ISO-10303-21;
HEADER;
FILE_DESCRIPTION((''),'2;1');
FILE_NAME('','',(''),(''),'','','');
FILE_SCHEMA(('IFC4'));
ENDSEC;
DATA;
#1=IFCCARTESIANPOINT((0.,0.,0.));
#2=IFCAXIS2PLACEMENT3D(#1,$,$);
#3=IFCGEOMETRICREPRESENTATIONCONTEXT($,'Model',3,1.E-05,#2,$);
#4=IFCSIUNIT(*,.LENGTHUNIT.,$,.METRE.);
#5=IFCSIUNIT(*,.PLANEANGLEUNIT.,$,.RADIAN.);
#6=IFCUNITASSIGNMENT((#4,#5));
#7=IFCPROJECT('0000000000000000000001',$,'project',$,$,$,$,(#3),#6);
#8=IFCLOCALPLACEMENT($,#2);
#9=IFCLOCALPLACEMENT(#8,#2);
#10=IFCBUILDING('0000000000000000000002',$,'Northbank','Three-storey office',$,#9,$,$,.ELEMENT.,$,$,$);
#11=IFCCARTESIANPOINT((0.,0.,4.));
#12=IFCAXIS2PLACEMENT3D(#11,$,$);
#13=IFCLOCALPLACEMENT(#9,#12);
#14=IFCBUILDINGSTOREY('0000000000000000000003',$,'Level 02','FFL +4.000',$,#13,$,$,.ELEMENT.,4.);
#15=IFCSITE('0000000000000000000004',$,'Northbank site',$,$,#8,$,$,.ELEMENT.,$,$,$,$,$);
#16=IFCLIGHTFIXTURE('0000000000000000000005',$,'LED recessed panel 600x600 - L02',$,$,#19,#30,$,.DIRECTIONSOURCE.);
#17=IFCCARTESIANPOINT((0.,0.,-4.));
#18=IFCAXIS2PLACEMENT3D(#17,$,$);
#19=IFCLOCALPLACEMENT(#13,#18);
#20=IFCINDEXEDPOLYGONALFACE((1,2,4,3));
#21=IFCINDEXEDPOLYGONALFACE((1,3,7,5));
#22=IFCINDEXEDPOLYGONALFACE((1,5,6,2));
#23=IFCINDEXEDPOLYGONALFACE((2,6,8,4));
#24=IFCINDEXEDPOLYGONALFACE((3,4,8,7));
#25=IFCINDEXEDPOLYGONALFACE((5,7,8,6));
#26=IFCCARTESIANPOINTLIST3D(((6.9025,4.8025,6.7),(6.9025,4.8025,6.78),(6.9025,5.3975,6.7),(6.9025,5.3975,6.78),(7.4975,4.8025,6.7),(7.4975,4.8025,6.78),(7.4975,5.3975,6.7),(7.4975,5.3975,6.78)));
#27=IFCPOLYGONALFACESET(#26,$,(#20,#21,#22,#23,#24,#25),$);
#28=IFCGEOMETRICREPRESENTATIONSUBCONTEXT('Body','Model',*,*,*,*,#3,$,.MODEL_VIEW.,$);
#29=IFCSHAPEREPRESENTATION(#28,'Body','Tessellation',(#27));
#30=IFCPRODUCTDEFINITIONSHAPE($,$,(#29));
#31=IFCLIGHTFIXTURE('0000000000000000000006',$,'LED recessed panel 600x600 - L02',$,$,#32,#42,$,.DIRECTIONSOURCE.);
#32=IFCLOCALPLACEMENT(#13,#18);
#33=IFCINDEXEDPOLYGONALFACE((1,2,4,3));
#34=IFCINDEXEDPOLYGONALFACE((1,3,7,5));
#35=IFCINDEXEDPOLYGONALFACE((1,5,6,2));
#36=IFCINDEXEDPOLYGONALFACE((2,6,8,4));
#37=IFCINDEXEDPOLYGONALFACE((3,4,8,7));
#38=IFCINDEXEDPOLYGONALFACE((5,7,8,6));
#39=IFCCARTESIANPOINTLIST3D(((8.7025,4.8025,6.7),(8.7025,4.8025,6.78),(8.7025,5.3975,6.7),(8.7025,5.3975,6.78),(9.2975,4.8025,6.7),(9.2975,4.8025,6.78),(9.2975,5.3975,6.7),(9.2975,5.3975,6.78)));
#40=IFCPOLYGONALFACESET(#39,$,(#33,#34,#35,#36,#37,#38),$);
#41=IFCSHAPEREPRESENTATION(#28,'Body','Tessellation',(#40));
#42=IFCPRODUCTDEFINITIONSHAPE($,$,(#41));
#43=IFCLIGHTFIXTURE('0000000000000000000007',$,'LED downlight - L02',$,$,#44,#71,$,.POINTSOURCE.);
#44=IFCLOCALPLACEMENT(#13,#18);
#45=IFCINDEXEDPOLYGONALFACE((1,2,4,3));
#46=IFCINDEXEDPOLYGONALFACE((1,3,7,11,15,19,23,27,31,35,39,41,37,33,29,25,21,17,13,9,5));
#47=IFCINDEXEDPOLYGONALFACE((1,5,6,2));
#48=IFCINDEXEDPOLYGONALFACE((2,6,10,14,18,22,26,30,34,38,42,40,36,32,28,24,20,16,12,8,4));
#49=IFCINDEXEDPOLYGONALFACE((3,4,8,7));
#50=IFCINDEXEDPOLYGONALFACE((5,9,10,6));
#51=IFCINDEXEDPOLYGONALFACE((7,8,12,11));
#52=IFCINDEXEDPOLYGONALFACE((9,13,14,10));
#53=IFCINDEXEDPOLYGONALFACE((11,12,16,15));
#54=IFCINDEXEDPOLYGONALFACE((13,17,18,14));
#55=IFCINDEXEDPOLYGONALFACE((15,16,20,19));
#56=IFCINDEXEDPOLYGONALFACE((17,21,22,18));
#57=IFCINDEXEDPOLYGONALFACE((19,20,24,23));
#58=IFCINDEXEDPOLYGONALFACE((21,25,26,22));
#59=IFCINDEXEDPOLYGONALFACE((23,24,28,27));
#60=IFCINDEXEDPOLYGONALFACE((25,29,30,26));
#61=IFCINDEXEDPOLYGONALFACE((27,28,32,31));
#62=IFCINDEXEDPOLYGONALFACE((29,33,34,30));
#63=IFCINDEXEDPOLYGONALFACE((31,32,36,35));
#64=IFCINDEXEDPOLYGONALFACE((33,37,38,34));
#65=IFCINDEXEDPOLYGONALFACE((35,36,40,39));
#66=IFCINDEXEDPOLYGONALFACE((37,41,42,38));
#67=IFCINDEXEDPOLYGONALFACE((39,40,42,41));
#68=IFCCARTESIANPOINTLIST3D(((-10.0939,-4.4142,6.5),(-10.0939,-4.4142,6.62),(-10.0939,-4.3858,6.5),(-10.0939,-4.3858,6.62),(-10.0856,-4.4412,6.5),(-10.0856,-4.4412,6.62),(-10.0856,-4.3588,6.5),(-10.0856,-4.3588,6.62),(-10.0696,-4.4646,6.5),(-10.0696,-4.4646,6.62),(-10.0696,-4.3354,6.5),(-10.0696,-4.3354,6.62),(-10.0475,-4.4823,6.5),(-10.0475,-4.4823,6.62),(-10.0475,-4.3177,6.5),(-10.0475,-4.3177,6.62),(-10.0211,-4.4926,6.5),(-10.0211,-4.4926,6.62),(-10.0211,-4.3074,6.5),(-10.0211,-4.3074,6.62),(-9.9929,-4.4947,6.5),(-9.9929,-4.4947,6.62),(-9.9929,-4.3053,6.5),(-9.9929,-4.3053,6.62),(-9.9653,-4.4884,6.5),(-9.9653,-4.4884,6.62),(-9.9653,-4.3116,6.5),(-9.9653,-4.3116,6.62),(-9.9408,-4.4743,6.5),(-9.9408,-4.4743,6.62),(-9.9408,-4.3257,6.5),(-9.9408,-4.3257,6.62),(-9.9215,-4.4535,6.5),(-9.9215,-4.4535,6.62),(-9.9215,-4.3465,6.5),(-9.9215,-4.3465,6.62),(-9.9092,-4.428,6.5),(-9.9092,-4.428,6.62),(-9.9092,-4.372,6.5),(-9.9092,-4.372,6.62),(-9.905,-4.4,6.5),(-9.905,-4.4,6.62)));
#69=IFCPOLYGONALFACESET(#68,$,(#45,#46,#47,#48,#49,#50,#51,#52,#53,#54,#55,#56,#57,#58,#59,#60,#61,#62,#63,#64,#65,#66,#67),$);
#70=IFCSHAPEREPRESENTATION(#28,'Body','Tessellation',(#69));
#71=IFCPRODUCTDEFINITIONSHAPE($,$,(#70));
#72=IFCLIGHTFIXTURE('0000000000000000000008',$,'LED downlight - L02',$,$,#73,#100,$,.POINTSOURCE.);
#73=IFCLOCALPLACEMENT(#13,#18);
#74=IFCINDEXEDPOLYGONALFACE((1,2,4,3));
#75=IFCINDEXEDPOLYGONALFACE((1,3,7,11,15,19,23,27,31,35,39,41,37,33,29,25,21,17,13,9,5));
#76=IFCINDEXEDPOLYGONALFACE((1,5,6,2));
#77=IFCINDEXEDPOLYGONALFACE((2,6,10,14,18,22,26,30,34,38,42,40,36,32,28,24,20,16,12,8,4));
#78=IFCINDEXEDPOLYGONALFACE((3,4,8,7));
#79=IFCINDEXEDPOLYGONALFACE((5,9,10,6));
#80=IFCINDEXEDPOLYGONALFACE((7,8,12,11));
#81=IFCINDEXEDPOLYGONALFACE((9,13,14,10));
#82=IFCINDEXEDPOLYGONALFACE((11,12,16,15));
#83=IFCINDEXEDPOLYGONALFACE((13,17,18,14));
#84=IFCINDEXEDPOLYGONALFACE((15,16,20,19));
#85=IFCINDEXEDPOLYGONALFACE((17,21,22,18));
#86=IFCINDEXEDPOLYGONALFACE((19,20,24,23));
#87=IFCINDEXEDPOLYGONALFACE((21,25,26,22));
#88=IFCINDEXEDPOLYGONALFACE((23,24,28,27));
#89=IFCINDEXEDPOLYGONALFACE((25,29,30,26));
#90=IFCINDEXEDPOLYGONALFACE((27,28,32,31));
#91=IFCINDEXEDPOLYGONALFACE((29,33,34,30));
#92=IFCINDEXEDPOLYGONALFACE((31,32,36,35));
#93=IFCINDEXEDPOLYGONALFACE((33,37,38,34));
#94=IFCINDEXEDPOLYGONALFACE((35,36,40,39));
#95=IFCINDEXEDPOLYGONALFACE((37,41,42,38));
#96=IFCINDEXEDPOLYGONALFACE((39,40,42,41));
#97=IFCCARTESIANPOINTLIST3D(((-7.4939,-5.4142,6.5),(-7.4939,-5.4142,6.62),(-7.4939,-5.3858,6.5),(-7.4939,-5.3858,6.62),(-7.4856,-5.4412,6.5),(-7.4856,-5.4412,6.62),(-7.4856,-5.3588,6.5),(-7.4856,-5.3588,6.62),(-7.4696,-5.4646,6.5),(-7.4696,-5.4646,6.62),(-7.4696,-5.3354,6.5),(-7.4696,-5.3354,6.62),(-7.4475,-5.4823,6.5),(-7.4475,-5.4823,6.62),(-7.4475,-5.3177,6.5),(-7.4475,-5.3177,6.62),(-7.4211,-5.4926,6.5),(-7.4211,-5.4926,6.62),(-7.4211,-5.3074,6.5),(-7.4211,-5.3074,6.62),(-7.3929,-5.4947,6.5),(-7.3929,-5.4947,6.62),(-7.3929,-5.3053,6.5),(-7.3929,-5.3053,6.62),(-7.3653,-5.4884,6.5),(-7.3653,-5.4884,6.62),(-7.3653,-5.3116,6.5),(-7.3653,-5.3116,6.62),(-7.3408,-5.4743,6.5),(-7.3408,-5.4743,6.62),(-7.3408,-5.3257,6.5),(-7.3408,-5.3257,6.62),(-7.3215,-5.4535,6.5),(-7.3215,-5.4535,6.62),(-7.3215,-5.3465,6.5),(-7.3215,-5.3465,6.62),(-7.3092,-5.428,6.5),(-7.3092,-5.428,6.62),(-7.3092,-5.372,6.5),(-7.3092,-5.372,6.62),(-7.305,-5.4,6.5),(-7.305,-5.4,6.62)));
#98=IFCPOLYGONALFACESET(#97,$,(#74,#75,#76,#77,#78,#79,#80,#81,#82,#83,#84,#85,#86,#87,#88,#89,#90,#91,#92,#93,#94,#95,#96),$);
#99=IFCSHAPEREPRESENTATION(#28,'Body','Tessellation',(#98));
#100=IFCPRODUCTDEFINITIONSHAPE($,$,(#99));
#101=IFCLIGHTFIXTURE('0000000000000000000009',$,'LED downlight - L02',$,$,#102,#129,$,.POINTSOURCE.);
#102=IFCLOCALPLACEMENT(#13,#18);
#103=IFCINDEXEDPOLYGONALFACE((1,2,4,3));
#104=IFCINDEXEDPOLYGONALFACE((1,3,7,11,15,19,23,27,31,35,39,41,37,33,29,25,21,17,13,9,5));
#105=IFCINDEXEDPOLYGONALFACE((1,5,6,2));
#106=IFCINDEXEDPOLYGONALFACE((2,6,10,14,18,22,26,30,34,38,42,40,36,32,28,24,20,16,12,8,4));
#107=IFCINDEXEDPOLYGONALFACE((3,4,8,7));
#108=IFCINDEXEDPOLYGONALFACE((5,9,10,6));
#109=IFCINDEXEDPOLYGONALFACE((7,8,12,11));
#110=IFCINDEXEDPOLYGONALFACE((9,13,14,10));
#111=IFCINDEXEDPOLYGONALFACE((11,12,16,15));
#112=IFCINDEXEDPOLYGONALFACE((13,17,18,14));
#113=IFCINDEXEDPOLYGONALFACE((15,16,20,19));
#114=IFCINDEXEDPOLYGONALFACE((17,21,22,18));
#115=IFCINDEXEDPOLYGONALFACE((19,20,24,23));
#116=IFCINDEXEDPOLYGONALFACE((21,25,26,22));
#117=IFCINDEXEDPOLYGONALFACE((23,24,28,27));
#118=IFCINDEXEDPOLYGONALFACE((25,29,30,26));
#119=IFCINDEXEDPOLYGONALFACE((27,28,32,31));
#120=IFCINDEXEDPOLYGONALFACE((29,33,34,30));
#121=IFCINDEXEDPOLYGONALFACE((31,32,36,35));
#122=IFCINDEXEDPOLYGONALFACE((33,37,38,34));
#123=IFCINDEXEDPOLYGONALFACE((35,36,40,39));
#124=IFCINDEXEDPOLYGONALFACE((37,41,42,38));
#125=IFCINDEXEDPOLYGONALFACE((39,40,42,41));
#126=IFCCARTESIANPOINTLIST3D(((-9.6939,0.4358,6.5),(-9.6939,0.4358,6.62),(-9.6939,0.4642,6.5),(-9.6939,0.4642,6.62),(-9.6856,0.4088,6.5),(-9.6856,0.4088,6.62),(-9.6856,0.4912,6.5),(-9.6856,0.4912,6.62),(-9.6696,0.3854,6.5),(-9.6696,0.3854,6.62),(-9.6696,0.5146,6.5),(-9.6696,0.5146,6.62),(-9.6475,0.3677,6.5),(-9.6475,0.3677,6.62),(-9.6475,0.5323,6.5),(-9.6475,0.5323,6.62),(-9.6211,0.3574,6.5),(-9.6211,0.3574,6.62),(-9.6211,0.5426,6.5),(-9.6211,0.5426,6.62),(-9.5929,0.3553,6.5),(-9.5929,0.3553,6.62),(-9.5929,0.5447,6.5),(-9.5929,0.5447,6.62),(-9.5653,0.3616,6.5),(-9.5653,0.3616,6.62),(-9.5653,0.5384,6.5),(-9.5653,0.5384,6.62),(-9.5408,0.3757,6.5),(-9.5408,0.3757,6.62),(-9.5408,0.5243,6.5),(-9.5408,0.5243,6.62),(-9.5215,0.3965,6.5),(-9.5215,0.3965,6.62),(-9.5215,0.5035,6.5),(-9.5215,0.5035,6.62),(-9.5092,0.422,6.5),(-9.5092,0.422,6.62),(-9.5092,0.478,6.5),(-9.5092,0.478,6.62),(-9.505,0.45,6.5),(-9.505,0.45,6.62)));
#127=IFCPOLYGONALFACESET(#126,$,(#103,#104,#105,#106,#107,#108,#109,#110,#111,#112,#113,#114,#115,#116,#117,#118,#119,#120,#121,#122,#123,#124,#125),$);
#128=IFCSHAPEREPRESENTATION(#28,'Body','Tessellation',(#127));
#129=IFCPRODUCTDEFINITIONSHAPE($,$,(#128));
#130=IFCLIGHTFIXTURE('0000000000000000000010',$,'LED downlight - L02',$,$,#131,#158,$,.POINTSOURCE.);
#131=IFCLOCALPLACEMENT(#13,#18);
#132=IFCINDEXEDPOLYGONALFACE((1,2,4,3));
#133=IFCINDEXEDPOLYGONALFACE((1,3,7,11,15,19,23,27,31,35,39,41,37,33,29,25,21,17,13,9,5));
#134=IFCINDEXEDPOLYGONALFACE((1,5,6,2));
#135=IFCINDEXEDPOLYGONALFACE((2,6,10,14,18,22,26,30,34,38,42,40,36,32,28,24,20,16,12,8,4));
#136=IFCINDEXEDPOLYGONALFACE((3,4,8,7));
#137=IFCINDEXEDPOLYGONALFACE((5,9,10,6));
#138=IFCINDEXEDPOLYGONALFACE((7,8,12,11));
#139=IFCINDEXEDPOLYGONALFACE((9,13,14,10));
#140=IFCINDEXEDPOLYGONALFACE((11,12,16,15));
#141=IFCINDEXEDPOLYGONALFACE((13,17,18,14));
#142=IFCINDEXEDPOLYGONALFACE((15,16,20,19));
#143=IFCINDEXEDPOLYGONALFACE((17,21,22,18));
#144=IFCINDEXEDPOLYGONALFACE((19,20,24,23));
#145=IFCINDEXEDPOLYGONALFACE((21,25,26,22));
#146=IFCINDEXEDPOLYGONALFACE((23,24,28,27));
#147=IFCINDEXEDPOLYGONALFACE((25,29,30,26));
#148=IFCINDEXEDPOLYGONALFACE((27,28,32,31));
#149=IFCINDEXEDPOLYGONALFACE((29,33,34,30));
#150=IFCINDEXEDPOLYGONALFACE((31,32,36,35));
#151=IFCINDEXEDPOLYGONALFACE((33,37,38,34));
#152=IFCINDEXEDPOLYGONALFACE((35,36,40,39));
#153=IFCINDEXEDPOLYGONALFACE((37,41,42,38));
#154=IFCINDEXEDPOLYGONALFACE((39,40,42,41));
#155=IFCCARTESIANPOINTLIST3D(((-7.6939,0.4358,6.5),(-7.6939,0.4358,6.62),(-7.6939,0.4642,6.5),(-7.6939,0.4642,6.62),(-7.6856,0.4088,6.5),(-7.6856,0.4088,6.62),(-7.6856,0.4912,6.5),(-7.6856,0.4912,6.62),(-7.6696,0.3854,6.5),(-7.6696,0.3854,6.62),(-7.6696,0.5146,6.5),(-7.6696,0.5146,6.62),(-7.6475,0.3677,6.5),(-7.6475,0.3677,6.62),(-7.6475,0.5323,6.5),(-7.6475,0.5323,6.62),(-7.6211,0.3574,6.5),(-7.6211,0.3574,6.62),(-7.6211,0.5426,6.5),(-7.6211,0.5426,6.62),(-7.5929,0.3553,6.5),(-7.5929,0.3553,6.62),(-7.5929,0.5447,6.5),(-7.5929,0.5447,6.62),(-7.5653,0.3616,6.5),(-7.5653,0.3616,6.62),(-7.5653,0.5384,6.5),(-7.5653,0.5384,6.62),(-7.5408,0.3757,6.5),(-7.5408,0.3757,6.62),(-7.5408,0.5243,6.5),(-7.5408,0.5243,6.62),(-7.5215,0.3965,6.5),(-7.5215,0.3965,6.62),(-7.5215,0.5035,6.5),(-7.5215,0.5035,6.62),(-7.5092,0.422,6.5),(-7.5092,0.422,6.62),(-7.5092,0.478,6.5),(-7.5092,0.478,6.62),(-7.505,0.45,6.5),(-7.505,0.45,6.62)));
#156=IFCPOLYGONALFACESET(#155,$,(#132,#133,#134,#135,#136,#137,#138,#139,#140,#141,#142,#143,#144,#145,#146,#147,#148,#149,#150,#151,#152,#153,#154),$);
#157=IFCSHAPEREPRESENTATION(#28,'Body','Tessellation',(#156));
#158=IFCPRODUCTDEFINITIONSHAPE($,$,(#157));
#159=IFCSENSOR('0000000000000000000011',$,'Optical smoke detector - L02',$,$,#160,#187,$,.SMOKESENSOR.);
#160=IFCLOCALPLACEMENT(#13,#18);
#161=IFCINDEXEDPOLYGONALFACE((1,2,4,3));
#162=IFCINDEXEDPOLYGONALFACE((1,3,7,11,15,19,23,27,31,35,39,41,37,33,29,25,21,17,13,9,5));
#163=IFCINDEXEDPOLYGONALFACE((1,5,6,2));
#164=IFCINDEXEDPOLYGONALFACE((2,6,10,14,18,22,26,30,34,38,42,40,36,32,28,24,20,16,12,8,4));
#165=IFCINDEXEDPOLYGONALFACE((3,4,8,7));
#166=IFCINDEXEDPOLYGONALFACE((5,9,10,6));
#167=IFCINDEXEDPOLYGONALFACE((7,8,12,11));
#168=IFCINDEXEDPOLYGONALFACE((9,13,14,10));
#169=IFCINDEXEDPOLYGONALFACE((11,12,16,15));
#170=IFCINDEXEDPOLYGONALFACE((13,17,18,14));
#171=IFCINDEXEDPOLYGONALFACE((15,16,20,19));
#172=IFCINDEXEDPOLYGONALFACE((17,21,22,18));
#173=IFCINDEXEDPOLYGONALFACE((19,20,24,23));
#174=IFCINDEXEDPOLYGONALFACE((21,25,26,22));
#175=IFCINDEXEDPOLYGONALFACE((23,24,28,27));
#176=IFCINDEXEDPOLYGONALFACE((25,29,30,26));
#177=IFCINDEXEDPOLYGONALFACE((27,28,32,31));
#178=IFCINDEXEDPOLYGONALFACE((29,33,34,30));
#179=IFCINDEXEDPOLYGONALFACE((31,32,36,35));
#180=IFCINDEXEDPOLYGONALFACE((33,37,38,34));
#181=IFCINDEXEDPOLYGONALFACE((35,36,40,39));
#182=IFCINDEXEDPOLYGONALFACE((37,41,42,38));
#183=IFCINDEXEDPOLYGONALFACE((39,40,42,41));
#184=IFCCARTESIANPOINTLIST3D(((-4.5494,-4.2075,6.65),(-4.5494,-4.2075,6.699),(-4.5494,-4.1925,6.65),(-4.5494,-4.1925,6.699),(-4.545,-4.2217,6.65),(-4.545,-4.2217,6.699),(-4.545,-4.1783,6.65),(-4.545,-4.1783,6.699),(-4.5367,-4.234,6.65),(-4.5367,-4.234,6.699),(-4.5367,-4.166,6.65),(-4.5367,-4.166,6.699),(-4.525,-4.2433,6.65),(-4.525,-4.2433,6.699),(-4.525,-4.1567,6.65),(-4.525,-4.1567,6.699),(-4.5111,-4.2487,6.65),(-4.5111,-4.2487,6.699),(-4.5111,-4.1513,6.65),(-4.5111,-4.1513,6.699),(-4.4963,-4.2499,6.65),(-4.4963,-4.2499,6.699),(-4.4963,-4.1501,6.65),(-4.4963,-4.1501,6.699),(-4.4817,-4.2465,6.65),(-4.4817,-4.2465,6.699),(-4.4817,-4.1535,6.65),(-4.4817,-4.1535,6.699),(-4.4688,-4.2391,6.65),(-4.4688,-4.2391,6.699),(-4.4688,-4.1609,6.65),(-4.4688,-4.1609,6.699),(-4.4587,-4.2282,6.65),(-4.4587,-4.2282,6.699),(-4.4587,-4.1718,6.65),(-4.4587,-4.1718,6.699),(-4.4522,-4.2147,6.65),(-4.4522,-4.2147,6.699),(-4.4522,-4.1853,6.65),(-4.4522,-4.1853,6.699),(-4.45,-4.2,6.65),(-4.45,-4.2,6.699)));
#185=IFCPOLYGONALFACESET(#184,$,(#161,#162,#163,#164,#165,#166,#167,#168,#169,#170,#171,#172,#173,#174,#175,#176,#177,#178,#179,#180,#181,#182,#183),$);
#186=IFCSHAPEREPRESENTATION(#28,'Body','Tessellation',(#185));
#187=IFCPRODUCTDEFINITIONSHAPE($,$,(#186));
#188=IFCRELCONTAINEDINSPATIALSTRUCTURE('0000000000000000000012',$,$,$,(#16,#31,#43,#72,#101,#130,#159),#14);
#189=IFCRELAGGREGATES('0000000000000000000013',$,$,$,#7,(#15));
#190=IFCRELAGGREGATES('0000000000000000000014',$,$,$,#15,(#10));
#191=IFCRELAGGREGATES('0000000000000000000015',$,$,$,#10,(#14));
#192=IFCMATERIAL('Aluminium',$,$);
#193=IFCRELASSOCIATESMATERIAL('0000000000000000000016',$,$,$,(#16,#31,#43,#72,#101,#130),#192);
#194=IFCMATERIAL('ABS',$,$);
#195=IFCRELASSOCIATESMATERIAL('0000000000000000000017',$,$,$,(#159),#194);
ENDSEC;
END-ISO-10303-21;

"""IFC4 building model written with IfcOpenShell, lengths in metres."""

from ifc_helpers import new_model, si_unit, frame, origin, place, context, subcontext, project, spatial, rectangle, circle, extrude, material, element, save


model = new_model("IFC4")

# Units and contexts
model_context = context("Model", 3, precision=1e-05, world=origin())
body_context = subcontext(model_context, "Body", "Model", "MODEL_VIEW")
ifc_project = project(units=[si_unit("LENGTHUNIT", "METRE"), si_unit("PLANEANGLEUNIT", "RADIAN")], contexts=[model_context])

# Site, building, storey
site_placement = place(None, origin())
site = spatial("IfcSite", under=ifc_project, at=site_placement, Name="Northbank site", CompositionType="ELEMENT")
building_placement = place(site_placement, origin())
building = spatial("IfcBuilding", under=site, at=building_placement, Name="Northbank", Description="Three-storey office", CompositionType="ELEMENT")
storey_placement = place(building_placement, frame((0.0, 0.0, 4.0)))
storey = spatial("IfcBuildingStorey", under=building, at=storey_placement, Name="Level 02", Description="FFL +4.000", CompositionType="ELEMENT", Elevation=4.0)

# Light fixtures
ifc_material_1 = material(Name="Aluminium")
light_fixture_1_placement = place(storey_placement, frame((0.0, 0.0, -4.0)))
element("IfcLightFixture", 1, at=light_fixture_1_placement, inside=storey, material=ifc_material_1, Name="LED recessed panel 600x600 - L02", PredefinedType="DIRECTIONSOURCE", context=body_context, shape_type="SweptSolid", body=[
    extrude(rectangle(XDim=0.595, YDim=0.595), frame((7.2, 5.1, 6.7)), (0.0, 0.0, 1.0), 0.08),
])
light_fixture_2_placement = place(storey_placement, frame((0.0, 0.0, -4.0)))
element("IfcLightFixture", 2, at=light_fixture_2_placement, inside=storey, material=ifc_material_1, Name="LED recessed panel 600x600 - L02", PredefinedType="DIRECTIONSOURCE", context=body_context, shape_type="SweptSolid", body=[
    extrude(rectangle(XDim=0.595, YDim=0.595), frame((9.0, 5.1, 6.7)), (0.0, 0.0, 1.0), 0.08),
])
light_fixture_3_placement = place(storey_placement, frame((0.0, 0.0, -4.0)))
element("IfcLightFixture", 3, at=light_fixture_3_placement, inside=storey, material=ifc_material_1, Name="LED downlight - L02", PredefinedType="POINTSOURCE", context=body_context, shape_type="SweptSolid", body=[
    extrude(circle(Radius=0.095), frame((-10.0, -4.4, 6.5), z_axis=(0.0, 0.0, 1.0), x_axis=(1.0, 0.0, 0.0)), (0.0, 0.0, 1.0), 0.12),
])
light_fixture_4_placement = place(storey_placement, frame((0.0, 0.0, -4.0)))
element("IfcLightFixture", 4, at=light_fixture_4_placement, inside=storey, material=ifc_material_1, Name="LED downlight - L02", PredefinedType="POINTSOURCE", context=body_context, shape_type="SweptSolid", body=[
    extrude(circle(Radius=0.095), frame((-7.4, -5.4, 6.5), z_axis=(0.0, 0.0, 1.0), x_axis=(1.0, 0.0, 0.0)), (0.0, 0.0, 1.0), 0.12),
])
light_fixture_5_placement = place(storey_placement, frame((0.0, 0.0, -4.0)))
element("IfcLightFixture", 5, at=light_fixture_5_placement, inside=storey, material=ifc_material_1, Name="LED downlight - L02", PredefinedType="POINTSOURCE", context=body_context, shape_type="SweptSolid", body=[
    extrude(circle(Radius=0.095), frame((-9.6, 0.45, 6.5), z_axis=(0.0, 0.0, 1.0), x_axis=(1.0, 0.0, 0.0)), (0.0, 0.0, 1.0), 0.12),
])
light_fixture_6_placement = place(storey_placement, frame((0.0, 0.0, -4.0)))
element("IfcLightFixture", 6, at=light_fixture_6_placement, inside=storey, material=ifc_material_1, Name="LED downlight - L02", PredefinedType="POINTSOURCE", context=body_context, shape_type="SweptSolid", body=[
    extrude(circle(Radius=0.095), frame((-7.6, 0.45, 6.5), z_axis=(0.0, 0.0, 1.0), x_axis=(1.0, 0.0, 0.0)), (0.0, 0.0, 1.0), 0.12),
])

# Sensor
ifc_material_2 = material(Name="ABS")
sensor_1_placement = place(storey_placement, frame((0.0, 0.0, -4.0)))
element("IfcSensor", 7, at=sensor_1_placement, inside=storey, material=ifc_material_2, Name="Optical smoke detector - L02", PredefinedType="SMOKESENSOR", context=body_context, shape_type="SweptSolid", body=[
    extrude(circle(Radius=0.05), frame((-4.5, -4.2, 6.65), z_axis=(0.0, 0.0, 1.0), x_axis=(1.0, 0.0, 0.0)), (0.0, 0.0, 1.0), 0.049),
])

save(model, "model.ifc")
